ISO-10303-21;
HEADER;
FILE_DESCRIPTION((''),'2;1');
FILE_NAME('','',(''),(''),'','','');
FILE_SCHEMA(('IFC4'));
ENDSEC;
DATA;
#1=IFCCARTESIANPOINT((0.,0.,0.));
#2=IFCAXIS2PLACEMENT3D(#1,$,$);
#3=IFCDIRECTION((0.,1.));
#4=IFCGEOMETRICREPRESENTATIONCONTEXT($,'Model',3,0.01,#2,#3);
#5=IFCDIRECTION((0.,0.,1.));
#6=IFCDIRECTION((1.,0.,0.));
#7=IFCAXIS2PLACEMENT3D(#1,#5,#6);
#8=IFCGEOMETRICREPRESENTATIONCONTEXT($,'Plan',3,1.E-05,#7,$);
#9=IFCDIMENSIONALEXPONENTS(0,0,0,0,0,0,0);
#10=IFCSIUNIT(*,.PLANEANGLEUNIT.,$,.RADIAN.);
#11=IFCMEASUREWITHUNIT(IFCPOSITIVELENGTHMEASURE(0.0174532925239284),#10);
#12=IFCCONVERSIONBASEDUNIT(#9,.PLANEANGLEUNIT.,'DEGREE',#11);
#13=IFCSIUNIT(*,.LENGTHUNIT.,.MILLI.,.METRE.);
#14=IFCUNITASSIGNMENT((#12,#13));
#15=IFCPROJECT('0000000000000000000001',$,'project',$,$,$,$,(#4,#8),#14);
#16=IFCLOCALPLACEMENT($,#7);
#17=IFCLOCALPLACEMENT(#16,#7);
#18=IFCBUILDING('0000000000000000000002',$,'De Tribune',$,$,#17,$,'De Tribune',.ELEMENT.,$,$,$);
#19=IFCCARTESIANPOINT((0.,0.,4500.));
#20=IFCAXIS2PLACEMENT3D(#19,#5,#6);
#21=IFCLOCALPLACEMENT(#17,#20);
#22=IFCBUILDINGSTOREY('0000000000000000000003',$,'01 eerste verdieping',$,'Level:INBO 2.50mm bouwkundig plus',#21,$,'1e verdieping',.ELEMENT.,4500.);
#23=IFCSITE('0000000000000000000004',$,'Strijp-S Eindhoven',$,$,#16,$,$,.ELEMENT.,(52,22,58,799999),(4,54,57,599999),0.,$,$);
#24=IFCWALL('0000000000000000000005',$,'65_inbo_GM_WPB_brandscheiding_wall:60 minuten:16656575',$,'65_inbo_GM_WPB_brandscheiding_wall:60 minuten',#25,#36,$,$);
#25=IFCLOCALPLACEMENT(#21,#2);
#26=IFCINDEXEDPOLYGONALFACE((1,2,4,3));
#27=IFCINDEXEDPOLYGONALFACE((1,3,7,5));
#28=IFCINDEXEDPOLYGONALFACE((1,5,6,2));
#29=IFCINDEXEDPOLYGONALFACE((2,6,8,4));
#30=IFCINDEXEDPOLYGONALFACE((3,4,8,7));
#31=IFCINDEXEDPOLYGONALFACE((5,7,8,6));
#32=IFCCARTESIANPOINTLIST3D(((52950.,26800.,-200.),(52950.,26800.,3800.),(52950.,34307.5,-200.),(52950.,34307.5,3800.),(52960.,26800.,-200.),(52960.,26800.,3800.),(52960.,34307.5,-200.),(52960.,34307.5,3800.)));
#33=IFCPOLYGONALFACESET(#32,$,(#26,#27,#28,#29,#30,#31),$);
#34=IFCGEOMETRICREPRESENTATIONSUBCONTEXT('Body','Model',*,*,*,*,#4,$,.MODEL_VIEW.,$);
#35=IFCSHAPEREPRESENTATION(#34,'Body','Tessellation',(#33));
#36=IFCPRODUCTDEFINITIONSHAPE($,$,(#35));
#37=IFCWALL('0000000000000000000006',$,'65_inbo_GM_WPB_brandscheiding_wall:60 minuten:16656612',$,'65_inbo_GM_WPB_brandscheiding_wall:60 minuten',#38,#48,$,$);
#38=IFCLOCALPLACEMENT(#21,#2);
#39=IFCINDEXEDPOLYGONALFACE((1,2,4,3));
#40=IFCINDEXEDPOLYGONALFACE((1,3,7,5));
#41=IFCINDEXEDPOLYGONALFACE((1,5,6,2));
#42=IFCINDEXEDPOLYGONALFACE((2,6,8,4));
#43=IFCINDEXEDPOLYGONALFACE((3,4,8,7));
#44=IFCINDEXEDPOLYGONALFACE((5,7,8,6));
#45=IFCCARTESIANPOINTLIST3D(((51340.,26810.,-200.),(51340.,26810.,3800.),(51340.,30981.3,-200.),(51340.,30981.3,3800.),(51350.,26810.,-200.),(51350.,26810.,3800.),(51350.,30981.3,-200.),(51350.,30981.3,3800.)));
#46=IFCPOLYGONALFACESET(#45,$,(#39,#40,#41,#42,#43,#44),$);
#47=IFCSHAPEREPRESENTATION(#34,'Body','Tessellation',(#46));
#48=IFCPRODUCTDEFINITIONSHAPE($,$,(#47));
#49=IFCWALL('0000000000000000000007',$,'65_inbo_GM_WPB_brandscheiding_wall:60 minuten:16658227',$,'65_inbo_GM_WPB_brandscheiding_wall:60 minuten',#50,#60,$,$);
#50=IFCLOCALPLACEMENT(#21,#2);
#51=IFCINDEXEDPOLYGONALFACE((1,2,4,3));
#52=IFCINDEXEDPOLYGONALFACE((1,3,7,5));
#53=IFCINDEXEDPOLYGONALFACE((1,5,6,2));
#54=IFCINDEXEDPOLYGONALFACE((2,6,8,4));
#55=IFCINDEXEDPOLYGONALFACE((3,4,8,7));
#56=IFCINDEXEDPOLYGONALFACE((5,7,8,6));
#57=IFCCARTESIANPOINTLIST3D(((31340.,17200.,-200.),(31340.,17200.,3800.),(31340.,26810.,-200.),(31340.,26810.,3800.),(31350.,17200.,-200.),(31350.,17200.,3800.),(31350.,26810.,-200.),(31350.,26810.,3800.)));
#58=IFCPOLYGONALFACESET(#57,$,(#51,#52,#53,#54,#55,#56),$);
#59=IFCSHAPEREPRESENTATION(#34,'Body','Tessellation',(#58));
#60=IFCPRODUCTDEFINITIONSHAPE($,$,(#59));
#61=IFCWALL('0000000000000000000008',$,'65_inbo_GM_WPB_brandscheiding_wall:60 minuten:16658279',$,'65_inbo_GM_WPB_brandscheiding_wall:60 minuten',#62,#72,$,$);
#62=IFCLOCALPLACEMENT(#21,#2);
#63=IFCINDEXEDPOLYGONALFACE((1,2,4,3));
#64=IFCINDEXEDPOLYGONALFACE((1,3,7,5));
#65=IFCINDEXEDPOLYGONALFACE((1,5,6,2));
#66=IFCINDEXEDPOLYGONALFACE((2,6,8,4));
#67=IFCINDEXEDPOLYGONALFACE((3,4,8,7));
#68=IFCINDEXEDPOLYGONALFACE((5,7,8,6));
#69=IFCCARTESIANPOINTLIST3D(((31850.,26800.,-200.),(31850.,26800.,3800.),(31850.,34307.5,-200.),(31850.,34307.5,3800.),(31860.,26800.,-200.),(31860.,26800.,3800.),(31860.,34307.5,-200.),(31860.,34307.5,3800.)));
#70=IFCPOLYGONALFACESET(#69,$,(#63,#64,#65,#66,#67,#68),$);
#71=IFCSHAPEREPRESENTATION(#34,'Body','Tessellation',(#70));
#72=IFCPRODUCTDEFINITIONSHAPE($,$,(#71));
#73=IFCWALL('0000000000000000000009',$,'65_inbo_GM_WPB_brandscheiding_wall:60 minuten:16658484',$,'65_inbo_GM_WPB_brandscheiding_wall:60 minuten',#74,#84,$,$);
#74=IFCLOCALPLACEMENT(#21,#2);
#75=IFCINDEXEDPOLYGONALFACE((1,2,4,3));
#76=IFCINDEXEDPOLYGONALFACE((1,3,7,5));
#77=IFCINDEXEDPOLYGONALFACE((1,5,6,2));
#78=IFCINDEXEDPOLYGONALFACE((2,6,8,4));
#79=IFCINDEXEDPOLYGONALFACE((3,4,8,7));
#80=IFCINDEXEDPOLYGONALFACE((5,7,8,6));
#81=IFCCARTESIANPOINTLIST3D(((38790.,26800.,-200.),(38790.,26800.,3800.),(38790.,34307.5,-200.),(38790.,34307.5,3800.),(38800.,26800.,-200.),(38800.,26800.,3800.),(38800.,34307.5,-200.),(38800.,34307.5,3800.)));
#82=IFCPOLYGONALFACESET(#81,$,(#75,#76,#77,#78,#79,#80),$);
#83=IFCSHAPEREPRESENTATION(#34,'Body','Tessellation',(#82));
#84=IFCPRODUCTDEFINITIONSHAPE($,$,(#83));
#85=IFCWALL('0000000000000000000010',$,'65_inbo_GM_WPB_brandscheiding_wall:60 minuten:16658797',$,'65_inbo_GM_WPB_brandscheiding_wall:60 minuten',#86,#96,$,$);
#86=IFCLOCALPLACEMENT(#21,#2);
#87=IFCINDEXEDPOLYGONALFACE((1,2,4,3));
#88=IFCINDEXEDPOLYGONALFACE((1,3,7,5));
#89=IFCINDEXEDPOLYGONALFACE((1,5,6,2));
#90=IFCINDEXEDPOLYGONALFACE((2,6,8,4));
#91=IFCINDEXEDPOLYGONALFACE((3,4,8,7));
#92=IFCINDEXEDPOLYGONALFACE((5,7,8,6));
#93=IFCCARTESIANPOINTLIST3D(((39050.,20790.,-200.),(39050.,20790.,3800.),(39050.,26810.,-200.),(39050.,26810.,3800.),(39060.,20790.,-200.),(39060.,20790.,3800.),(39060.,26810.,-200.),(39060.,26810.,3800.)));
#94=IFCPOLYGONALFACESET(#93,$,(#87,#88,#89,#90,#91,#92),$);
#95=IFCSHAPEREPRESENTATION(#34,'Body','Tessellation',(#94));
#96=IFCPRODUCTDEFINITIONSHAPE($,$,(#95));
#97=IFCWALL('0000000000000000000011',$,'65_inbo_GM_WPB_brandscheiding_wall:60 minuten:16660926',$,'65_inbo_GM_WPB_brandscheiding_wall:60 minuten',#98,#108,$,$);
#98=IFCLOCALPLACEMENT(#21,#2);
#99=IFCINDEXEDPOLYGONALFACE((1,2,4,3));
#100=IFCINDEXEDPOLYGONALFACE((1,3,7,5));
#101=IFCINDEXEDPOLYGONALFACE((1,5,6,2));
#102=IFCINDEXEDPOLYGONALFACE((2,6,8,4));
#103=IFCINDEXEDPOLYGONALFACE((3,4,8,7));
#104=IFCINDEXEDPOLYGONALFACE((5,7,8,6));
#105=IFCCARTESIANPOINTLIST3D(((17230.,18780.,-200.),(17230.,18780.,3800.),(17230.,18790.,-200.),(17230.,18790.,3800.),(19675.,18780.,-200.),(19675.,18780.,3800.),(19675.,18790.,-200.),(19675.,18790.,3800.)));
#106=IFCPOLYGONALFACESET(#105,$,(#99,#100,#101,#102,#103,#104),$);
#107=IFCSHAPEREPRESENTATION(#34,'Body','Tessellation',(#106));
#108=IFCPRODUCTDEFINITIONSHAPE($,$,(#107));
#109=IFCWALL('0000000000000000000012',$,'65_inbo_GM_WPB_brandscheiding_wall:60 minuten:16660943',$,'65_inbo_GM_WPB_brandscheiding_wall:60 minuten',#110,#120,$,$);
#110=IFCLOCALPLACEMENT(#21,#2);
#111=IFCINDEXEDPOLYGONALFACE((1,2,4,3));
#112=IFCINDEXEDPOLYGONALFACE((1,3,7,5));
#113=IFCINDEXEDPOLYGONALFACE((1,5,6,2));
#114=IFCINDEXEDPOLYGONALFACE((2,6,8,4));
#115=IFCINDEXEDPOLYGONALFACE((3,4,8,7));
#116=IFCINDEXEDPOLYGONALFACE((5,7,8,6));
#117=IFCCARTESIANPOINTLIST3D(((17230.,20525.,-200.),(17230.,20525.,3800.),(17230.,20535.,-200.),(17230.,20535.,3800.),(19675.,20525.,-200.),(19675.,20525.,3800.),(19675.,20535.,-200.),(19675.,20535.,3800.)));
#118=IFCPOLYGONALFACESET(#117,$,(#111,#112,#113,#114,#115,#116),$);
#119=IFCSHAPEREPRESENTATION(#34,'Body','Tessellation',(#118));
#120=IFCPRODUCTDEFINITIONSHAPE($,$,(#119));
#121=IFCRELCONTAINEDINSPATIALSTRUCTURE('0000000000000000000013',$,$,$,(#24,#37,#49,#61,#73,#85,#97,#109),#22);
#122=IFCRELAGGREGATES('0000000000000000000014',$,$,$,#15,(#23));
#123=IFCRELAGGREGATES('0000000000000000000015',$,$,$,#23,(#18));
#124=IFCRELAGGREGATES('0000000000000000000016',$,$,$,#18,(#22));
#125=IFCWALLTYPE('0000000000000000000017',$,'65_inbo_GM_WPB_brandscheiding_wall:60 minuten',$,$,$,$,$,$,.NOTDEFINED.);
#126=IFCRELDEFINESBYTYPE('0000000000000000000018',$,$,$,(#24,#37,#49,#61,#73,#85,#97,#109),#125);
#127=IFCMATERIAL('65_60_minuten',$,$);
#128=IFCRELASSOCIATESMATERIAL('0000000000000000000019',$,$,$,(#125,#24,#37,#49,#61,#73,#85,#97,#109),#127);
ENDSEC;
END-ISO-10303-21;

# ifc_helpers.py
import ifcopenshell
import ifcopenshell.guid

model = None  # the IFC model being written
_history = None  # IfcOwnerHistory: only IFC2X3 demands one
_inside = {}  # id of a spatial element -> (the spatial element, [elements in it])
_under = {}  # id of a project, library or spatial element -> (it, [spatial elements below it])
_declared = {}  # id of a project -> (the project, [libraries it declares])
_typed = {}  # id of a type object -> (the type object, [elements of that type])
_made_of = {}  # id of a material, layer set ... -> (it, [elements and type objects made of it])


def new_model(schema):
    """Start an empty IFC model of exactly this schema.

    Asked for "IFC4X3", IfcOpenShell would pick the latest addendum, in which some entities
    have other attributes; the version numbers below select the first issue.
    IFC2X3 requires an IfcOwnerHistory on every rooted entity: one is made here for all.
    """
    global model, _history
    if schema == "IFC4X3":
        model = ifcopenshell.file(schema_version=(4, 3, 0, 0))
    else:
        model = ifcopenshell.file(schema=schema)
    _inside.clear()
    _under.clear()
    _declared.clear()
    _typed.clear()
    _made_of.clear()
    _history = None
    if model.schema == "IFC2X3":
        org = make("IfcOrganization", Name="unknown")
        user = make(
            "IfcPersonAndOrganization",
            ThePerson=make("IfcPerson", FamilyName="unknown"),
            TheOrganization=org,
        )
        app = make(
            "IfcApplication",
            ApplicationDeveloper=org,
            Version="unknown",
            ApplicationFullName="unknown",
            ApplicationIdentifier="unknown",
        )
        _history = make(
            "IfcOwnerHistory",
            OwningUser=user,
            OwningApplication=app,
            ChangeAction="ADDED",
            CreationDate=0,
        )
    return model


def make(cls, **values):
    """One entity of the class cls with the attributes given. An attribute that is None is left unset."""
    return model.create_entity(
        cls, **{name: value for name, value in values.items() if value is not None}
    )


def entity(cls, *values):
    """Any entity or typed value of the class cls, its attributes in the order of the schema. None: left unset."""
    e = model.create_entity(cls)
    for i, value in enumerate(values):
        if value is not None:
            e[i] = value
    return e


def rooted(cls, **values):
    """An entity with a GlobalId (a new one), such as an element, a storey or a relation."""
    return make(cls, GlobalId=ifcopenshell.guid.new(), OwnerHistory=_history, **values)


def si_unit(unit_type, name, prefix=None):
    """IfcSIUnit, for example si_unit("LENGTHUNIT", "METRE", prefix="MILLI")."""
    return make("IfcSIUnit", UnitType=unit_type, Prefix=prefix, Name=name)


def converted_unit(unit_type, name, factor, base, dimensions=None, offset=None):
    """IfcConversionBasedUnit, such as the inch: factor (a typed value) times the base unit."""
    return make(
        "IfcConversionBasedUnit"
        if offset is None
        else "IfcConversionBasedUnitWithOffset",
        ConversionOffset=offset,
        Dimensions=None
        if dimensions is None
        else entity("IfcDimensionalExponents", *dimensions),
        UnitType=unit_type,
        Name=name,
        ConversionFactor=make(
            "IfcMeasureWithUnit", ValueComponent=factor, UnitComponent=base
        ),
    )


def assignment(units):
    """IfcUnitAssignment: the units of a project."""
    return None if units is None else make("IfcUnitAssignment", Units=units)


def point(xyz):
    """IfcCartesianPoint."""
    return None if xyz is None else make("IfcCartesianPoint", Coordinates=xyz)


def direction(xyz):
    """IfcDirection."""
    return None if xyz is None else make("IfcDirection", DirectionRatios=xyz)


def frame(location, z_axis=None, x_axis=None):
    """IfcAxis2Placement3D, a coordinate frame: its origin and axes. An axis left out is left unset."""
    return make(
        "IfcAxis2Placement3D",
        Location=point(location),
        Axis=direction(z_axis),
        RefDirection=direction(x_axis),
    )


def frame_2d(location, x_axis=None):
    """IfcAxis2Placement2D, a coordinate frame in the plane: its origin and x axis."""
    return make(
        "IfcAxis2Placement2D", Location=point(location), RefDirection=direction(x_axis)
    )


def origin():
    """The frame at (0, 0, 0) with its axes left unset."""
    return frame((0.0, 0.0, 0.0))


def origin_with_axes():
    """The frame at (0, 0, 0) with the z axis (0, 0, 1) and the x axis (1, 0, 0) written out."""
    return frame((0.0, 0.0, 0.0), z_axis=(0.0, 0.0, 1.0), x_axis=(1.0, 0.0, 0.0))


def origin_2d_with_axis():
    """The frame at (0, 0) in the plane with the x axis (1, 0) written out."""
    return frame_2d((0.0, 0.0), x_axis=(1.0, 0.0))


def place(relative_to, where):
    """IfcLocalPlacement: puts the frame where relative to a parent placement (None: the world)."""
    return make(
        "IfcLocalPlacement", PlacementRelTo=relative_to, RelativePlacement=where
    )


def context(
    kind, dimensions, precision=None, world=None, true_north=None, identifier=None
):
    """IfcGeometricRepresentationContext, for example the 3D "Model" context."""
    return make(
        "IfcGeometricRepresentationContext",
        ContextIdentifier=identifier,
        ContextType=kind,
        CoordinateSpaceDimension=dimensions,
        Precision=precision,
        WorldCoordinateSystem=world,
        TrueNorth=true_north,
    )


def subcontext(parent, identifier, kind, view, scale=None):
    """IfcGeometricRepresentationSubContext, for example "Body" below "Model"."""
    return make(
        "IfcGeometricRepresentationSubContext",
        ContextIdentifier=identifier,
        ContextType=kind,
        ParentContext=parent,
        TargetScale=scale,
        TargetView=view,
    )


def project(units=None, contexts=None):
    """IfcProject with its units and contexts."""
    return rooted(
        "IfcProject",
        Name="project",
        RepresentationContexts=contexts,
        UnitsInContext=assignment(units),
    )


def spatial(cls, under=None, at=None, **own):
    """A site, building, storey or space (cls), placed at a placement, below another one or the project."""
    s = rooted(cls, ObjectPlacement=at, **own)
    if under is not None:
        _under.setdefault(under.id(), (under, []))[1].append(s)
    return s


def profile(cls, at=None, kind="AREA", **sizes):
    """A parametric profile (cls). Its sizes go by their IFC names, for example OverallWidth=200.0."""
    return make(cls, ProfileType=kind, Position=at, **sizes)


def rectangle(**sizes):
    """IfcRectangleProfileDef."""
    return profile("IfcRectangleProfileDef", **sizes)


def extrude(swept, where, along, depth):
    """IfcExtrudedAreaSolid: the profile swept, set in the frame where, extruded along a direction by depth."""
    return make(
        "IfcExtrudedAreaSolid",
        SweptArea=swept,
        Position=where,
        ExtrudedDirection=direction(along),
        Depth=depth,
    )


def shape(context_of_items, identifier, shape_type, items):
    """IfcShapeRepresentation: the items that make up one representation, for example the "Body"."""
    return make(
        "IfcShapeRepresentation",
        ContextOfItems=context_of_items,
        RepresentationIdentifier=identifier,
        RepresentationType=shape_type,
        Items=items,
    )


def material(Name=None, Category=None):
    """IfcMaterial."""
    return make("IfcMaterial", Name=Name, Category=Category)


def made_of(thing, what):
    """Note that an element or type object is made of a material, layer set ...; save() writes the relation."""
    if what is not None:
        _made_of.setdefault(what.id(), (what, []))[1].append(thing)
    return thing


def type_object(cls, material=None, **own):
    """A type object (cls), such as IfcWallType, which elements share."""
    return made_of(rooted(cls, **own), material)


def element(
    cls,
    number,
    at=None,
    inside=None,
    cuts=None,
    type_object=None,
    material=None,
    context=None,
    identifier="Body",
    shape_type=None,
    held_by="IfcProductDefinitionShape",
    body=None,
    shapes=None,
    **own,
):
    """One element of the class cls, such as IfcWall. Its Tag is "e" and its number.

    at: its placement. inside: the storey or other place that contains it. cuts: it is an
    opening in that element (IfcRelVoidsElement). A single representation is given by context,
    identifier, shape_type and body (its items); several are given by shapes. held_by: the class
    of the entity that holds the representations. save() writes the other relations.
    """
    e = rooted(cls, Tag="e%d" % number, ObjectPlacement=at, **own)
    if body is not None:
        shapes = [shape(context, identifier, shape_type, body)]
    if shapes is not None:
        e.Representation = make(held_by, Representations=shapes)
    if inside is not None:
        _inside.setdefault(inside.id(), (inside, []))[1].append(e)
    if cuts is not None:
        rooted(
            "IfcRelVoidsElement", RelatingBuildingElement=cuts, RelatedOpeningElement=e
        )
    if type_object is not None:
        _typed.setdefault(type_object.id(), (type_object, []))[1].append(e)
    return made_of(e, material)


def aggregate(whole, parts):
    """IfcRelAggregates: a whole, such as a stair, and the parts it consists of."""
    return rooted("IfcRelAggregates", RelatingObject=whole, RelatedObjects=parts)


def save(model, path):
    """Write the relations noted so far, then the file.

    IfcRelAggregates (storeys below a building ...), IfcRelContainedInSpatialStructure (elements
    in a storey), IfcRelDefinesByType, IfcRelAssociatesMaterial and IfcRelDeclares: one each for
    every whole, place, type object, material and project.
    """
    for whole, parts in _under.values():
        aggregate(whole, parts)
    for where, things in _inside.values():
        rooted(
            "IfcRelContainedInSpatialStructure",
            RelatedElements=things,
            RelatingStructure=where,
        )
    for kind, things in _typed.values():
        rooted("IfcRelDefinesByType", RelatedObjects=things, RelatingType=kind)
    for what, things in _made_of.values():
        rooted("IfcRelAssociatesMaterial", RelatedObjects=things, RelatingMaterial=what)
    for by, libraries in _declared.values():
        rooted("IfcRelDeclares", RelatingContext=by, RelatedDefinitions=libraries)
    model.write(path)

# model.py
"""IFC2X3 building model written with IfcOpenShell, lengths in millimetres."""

from ifc_helpers import new_model, entity, si_unit, converted_unit, direction, frame, frame_2d, origin, origin_with_axes, origin_2d_with_axis, place, context, subcontext, project, spatial, rectangle, extrude, material, type_object, element, save


model = new_model("IFC2X3")

# Units and contexts
model_context = context("Model", 3, precision=0.01, world=origin(), true_north=direction((0.0, 1.0)))
plan_context = context("Plan", 3, precision=1e-05, world=origin_with_axes())
body_context = subcontext(model_context, "Body", "Model", "MODEL_VIEW")
ifc_project = project(units=[converted_unit("PLANEANGLEUNIT", "DEGREE", entity("IfcPositiveLengthMeasure", 0.0174532925239284), si_unit("PLANEANGLEUNIT", "RADIAN"), dimensions=[0, 0, 0, 0, 0, 0, 0]), si_unit("LENGTHUNIT", "METRE", prefix="MILLI")], contexts=[model_context, plan_context])

# Site, building, storey
site_placement = place(None, origin_with_axes())
site = spatial("IfcSite", under=ifc_project, at=site_placement, Name="Strijp-S Eindhoven", CompositionType="ELEMENT", RefLatitude=(52, 22, 58, 799999), RefLongitude=(4, 54, 57, 599999), RefElevation=0.0)
building_placement = place(site_placement, origin_with_axes())
building = spatial("IfcBuilding", under=site, at=building_placement, Name="De Tribune", LongName="De Tribune", CompositionType="ELEMENT")
storey_placement = place(building_placement, frame((0.0, 0.0, 4500.0), z_axis=(0.0, 0.0, 1.0), x_axis=(1.0, 0.0, 0.0)))
storey = spatial("IfcBuildingStorey", under=building, at=storey_placement, Name="01 eerste verdieping", ObjectType="Level:INBO 2.50mm bouwkundig plus", LongName="1e verdieping", CompositionType="ELEMENT", Elevation=4500.0)

# Walls
ifc_material_1 = material(Name="65_60_minuten")
wall_type_1 = type_object("IfcWallType", Name="65_inbo_GM_WPB_brandscheiding_wall:60 minuten", PredefinedType="NOTDEFINED", material=ifc_material_1)
wall_1_placement = place(storey_placement, frame((52915.0, 26800.0, -200.0), z_axis=(0.0, 0.0, 1.0), x_axis=(0.0, 1.0, 0.0)))
element("IfcWall", 1, at=wall_1_placement, inside=storey, type_object=wall_type_1, material=ifc_material_1, Name="65_inbo_GM_WPB_brandscheiding_wall:60 minuten:16656575", ObjectType="65_inbo_GM_WPB_brandscheiding_wall:60 minuten", context=body_context, shape_type="SweptSolid", body=[
    extrude(rectangle(XDim=10.0, YDim=7507.5, at=frame_2d((0.0, 0.0), x_axis=(1.0, 0.0))), frame((3753.8, -40.0, 0.0), z_axis=(0.0, 0.0, 1.0), x_axis=(0.0, -1.0, 0.0)), (0.0, 0.0, 1.0), 4000.0),
])
wall_2_placement = place(storey_placement, frame((51305.0, 26810.0, -200.0), z_axis=(0.0, 0.0, 1.0), x_axis=(0.0, 1.0, 0.0)))
element("IfcWall", 2, at=wall_2_placement, inside=storey, type_object=wall_type_1, material=ifc_material_1, Name="65_inbo_GM_WPB_brandscheiding_wall:60 minuten:16656612", ObjectType="65_inbo_GM_WPB_brandscheiding_wall:60 minuten", context=body_context, shape_type="SweptSolid", body=[
    extrude(rectangle(XDim=10.0, YDim=4171.3, at=frame_2d((0.0, 0.0), x_axis=(1.0, 0.0))), frame((2085.7, -40.0, 0.0), z_axis=(0.0, 0.0, 1.0), x_axis=(0.0, -1.0, 0.0)), (0.0, 0.0, 1.0), 4000.0),
])
wall_3_placement = place(storey_placement, frame((31305.0, 17200.0, -200.0), z_axis=(0.0, 0.0, 1.0), x_axis=(0.0, 1.0, 0.0)))
element("IfcWall", 3, at=wall_3_placement, inside=storey, type_object=wall_type_1, material=ifc_material_1, Name="65_inbo_GM_WPB_brandscheiding_wall:60 minuten:16658227", ObjectType="65_inbo_GM_WPB_brandscheiding_wall:60 minuten", context=body_context, shape_type="SweptSolid", body=[
    extrude(rectangle(XDim=10.0, YDim=9610.0, at=frame_2d((0.0, 0.0), x_axis=(1.0, 0.0))), frame((4805.0, -40.0, 0.0), z_axis=(0.0, 0.0, 1.0), x_axis=(0.0, -1.0, 0.0)), (0.0, 0.0, 1.0), 4000.0),
])
wall_4_placement = place(storey_placement, frame((31815.0, 26800.0, -200.0), z_axis=(0.0, 0.0, 1.0), x_axis=(0.0, 1.0, 0.0)))
element("IfcWall", 4, at=wall_4_placement, inside=storey, type_object=wall_type_1, material=ifc_material_1, Name="65_inbo_GM_WPB_brandscheiding_wall:60 minuten:16658279", ObjectType="65_inbo_GM_WPB_brandscheiding_wall:60 minuten", context=body_context, shape_type="SweptSolid", body=[
    extrude(rectangle(XDim=10.0, YDim=7507.5, at=origin_2d_with_axis()), frame((3753.8, -40.0, 0.0), z_axis=(0.0, 0.0, 1.0), x_axis=(0.0, -1.0, 0.0)), (0.0, 0.0, 1.0), 4000.0),
])
wall_5_placement = place(storey_placement, frame((38755.0, 26800.0, -200.0), z_axis=(0.0, 0.0, 1.0), x_axis=(0.0, 1.0, 0.0)))
element("IfcWall", 5, at=wall_5_placement, inside=storey, type_object=wall_type_1, material=ifc_material_1, Name="65_inbo_GM_WPB_brandscheiding_wall:60 minuten:16658484", ObjectType="65_inbo_GM_WPB_brandscheiding_wall:60 minuten", context=body_context, shape_type="SweptSolid", body=[
    extrude(rectangle(XDim=10.0, YDim=7507.5, at=frame_2d((0.0, 0.0), x_axis=(1.0, 0.0))), frame((3753.8, -40.0, 0.0), z_axis=(0.0, 0.0, 1.0), x_axis=(0.0, -1.0, 0.0)), (0.0, 0.0, 1.0), 4000.0),
])
wall_6_placement = place(storey_placement, frame((39015.0, 20790.0, -200.0), z_axis=(0.0, 0.0, 1.0), x_axis=(0.0, 1.0, 0.0)))
element("IfcWall", 6, at=wall_6_placement, inside=storey, type_object=wall_type_1, material=ifc_material_1, Name="65_inbo_GM_WPB_brandscheiding_wall:60 minuten:16658797", ObjectType="65_inbo_GM_WPB_brandscheiding_wall:60 minuten", context=body_context, shape_type="SweptSolid", body=[
    extrude(rectangle(XDim=10.0, YDim=6020.0, at=frame_2d((0.0, 0.0), x_axis=(1.0, 0.0))), frame((3010.0, -40.0, 0.0), z_axis=(0.0, 0.0, 1.0), x_axis=(0.0, -1.0, 0.0)), (0.0, 0.0, 1.0), 4000.0),
])
wall_7_placement = place(storey_placement, frame((17230.0, 18604.1, -200.0), z_axis=(0.0, 0.0, 1.0), x_axis=(1.0, 0.0, 0.0)))
element("IfcWall", 7, at=wall_7_placement, inside=storey, type_object=wall_type_1, material=ifc_material_1, Name="65_inbo_GM_WPB_brandscheiding_wall:60 minuten:16660926", ObjectType="65_inbo_GM_WPB_brandscheiding_wall:60 minuten", context=body_context, shape_type="SweptSolid", body=[
    extrude(rectangle(XDim=10.0, YDim=2445.0, at=origin_2d_with_axis()), frame((1222.5, 180.9, 0.0), z_axis=(0.0, 0.0, 1.0), x_axis=(0.0, -1.0, 0.0)), (0.0, 0.0, 1.0), 4000.0),
])
wall_8_placement = place(storey_placement, frame((17230.0, 20349.1, -200.0), z_axis=(0.0, 0.0, 1.0), x_axis=(1.0, 0.0, 0.0)))
element("IfcWall", 8, at=wall_8_placement, inside=storey, type_object=wall_type_1, material=ifc_material_1, Name="65_inbo_GM_WPB_brandscheiding_wall:60 minuten:16660943", ObjectType="65_inbo_GM_WPB_brandscheiding_wall:60 minuten", context=body_context, shape_type="SweptSolid", body=[
    extrude(rectangle(XDim=10.0, YDim=2445.0, at=frame_2d((0.0, 0.0), x_axis=(1.0, 0.0))), frame((1222.5, 180.9, 0.0), z_axis=(0.0, 0.0, 1.0), x_axis=(0.0, -1.0, 0.0)), (0.0, 0.0, 1.0), 4000.0),
])

save(model, "model.ifc")
